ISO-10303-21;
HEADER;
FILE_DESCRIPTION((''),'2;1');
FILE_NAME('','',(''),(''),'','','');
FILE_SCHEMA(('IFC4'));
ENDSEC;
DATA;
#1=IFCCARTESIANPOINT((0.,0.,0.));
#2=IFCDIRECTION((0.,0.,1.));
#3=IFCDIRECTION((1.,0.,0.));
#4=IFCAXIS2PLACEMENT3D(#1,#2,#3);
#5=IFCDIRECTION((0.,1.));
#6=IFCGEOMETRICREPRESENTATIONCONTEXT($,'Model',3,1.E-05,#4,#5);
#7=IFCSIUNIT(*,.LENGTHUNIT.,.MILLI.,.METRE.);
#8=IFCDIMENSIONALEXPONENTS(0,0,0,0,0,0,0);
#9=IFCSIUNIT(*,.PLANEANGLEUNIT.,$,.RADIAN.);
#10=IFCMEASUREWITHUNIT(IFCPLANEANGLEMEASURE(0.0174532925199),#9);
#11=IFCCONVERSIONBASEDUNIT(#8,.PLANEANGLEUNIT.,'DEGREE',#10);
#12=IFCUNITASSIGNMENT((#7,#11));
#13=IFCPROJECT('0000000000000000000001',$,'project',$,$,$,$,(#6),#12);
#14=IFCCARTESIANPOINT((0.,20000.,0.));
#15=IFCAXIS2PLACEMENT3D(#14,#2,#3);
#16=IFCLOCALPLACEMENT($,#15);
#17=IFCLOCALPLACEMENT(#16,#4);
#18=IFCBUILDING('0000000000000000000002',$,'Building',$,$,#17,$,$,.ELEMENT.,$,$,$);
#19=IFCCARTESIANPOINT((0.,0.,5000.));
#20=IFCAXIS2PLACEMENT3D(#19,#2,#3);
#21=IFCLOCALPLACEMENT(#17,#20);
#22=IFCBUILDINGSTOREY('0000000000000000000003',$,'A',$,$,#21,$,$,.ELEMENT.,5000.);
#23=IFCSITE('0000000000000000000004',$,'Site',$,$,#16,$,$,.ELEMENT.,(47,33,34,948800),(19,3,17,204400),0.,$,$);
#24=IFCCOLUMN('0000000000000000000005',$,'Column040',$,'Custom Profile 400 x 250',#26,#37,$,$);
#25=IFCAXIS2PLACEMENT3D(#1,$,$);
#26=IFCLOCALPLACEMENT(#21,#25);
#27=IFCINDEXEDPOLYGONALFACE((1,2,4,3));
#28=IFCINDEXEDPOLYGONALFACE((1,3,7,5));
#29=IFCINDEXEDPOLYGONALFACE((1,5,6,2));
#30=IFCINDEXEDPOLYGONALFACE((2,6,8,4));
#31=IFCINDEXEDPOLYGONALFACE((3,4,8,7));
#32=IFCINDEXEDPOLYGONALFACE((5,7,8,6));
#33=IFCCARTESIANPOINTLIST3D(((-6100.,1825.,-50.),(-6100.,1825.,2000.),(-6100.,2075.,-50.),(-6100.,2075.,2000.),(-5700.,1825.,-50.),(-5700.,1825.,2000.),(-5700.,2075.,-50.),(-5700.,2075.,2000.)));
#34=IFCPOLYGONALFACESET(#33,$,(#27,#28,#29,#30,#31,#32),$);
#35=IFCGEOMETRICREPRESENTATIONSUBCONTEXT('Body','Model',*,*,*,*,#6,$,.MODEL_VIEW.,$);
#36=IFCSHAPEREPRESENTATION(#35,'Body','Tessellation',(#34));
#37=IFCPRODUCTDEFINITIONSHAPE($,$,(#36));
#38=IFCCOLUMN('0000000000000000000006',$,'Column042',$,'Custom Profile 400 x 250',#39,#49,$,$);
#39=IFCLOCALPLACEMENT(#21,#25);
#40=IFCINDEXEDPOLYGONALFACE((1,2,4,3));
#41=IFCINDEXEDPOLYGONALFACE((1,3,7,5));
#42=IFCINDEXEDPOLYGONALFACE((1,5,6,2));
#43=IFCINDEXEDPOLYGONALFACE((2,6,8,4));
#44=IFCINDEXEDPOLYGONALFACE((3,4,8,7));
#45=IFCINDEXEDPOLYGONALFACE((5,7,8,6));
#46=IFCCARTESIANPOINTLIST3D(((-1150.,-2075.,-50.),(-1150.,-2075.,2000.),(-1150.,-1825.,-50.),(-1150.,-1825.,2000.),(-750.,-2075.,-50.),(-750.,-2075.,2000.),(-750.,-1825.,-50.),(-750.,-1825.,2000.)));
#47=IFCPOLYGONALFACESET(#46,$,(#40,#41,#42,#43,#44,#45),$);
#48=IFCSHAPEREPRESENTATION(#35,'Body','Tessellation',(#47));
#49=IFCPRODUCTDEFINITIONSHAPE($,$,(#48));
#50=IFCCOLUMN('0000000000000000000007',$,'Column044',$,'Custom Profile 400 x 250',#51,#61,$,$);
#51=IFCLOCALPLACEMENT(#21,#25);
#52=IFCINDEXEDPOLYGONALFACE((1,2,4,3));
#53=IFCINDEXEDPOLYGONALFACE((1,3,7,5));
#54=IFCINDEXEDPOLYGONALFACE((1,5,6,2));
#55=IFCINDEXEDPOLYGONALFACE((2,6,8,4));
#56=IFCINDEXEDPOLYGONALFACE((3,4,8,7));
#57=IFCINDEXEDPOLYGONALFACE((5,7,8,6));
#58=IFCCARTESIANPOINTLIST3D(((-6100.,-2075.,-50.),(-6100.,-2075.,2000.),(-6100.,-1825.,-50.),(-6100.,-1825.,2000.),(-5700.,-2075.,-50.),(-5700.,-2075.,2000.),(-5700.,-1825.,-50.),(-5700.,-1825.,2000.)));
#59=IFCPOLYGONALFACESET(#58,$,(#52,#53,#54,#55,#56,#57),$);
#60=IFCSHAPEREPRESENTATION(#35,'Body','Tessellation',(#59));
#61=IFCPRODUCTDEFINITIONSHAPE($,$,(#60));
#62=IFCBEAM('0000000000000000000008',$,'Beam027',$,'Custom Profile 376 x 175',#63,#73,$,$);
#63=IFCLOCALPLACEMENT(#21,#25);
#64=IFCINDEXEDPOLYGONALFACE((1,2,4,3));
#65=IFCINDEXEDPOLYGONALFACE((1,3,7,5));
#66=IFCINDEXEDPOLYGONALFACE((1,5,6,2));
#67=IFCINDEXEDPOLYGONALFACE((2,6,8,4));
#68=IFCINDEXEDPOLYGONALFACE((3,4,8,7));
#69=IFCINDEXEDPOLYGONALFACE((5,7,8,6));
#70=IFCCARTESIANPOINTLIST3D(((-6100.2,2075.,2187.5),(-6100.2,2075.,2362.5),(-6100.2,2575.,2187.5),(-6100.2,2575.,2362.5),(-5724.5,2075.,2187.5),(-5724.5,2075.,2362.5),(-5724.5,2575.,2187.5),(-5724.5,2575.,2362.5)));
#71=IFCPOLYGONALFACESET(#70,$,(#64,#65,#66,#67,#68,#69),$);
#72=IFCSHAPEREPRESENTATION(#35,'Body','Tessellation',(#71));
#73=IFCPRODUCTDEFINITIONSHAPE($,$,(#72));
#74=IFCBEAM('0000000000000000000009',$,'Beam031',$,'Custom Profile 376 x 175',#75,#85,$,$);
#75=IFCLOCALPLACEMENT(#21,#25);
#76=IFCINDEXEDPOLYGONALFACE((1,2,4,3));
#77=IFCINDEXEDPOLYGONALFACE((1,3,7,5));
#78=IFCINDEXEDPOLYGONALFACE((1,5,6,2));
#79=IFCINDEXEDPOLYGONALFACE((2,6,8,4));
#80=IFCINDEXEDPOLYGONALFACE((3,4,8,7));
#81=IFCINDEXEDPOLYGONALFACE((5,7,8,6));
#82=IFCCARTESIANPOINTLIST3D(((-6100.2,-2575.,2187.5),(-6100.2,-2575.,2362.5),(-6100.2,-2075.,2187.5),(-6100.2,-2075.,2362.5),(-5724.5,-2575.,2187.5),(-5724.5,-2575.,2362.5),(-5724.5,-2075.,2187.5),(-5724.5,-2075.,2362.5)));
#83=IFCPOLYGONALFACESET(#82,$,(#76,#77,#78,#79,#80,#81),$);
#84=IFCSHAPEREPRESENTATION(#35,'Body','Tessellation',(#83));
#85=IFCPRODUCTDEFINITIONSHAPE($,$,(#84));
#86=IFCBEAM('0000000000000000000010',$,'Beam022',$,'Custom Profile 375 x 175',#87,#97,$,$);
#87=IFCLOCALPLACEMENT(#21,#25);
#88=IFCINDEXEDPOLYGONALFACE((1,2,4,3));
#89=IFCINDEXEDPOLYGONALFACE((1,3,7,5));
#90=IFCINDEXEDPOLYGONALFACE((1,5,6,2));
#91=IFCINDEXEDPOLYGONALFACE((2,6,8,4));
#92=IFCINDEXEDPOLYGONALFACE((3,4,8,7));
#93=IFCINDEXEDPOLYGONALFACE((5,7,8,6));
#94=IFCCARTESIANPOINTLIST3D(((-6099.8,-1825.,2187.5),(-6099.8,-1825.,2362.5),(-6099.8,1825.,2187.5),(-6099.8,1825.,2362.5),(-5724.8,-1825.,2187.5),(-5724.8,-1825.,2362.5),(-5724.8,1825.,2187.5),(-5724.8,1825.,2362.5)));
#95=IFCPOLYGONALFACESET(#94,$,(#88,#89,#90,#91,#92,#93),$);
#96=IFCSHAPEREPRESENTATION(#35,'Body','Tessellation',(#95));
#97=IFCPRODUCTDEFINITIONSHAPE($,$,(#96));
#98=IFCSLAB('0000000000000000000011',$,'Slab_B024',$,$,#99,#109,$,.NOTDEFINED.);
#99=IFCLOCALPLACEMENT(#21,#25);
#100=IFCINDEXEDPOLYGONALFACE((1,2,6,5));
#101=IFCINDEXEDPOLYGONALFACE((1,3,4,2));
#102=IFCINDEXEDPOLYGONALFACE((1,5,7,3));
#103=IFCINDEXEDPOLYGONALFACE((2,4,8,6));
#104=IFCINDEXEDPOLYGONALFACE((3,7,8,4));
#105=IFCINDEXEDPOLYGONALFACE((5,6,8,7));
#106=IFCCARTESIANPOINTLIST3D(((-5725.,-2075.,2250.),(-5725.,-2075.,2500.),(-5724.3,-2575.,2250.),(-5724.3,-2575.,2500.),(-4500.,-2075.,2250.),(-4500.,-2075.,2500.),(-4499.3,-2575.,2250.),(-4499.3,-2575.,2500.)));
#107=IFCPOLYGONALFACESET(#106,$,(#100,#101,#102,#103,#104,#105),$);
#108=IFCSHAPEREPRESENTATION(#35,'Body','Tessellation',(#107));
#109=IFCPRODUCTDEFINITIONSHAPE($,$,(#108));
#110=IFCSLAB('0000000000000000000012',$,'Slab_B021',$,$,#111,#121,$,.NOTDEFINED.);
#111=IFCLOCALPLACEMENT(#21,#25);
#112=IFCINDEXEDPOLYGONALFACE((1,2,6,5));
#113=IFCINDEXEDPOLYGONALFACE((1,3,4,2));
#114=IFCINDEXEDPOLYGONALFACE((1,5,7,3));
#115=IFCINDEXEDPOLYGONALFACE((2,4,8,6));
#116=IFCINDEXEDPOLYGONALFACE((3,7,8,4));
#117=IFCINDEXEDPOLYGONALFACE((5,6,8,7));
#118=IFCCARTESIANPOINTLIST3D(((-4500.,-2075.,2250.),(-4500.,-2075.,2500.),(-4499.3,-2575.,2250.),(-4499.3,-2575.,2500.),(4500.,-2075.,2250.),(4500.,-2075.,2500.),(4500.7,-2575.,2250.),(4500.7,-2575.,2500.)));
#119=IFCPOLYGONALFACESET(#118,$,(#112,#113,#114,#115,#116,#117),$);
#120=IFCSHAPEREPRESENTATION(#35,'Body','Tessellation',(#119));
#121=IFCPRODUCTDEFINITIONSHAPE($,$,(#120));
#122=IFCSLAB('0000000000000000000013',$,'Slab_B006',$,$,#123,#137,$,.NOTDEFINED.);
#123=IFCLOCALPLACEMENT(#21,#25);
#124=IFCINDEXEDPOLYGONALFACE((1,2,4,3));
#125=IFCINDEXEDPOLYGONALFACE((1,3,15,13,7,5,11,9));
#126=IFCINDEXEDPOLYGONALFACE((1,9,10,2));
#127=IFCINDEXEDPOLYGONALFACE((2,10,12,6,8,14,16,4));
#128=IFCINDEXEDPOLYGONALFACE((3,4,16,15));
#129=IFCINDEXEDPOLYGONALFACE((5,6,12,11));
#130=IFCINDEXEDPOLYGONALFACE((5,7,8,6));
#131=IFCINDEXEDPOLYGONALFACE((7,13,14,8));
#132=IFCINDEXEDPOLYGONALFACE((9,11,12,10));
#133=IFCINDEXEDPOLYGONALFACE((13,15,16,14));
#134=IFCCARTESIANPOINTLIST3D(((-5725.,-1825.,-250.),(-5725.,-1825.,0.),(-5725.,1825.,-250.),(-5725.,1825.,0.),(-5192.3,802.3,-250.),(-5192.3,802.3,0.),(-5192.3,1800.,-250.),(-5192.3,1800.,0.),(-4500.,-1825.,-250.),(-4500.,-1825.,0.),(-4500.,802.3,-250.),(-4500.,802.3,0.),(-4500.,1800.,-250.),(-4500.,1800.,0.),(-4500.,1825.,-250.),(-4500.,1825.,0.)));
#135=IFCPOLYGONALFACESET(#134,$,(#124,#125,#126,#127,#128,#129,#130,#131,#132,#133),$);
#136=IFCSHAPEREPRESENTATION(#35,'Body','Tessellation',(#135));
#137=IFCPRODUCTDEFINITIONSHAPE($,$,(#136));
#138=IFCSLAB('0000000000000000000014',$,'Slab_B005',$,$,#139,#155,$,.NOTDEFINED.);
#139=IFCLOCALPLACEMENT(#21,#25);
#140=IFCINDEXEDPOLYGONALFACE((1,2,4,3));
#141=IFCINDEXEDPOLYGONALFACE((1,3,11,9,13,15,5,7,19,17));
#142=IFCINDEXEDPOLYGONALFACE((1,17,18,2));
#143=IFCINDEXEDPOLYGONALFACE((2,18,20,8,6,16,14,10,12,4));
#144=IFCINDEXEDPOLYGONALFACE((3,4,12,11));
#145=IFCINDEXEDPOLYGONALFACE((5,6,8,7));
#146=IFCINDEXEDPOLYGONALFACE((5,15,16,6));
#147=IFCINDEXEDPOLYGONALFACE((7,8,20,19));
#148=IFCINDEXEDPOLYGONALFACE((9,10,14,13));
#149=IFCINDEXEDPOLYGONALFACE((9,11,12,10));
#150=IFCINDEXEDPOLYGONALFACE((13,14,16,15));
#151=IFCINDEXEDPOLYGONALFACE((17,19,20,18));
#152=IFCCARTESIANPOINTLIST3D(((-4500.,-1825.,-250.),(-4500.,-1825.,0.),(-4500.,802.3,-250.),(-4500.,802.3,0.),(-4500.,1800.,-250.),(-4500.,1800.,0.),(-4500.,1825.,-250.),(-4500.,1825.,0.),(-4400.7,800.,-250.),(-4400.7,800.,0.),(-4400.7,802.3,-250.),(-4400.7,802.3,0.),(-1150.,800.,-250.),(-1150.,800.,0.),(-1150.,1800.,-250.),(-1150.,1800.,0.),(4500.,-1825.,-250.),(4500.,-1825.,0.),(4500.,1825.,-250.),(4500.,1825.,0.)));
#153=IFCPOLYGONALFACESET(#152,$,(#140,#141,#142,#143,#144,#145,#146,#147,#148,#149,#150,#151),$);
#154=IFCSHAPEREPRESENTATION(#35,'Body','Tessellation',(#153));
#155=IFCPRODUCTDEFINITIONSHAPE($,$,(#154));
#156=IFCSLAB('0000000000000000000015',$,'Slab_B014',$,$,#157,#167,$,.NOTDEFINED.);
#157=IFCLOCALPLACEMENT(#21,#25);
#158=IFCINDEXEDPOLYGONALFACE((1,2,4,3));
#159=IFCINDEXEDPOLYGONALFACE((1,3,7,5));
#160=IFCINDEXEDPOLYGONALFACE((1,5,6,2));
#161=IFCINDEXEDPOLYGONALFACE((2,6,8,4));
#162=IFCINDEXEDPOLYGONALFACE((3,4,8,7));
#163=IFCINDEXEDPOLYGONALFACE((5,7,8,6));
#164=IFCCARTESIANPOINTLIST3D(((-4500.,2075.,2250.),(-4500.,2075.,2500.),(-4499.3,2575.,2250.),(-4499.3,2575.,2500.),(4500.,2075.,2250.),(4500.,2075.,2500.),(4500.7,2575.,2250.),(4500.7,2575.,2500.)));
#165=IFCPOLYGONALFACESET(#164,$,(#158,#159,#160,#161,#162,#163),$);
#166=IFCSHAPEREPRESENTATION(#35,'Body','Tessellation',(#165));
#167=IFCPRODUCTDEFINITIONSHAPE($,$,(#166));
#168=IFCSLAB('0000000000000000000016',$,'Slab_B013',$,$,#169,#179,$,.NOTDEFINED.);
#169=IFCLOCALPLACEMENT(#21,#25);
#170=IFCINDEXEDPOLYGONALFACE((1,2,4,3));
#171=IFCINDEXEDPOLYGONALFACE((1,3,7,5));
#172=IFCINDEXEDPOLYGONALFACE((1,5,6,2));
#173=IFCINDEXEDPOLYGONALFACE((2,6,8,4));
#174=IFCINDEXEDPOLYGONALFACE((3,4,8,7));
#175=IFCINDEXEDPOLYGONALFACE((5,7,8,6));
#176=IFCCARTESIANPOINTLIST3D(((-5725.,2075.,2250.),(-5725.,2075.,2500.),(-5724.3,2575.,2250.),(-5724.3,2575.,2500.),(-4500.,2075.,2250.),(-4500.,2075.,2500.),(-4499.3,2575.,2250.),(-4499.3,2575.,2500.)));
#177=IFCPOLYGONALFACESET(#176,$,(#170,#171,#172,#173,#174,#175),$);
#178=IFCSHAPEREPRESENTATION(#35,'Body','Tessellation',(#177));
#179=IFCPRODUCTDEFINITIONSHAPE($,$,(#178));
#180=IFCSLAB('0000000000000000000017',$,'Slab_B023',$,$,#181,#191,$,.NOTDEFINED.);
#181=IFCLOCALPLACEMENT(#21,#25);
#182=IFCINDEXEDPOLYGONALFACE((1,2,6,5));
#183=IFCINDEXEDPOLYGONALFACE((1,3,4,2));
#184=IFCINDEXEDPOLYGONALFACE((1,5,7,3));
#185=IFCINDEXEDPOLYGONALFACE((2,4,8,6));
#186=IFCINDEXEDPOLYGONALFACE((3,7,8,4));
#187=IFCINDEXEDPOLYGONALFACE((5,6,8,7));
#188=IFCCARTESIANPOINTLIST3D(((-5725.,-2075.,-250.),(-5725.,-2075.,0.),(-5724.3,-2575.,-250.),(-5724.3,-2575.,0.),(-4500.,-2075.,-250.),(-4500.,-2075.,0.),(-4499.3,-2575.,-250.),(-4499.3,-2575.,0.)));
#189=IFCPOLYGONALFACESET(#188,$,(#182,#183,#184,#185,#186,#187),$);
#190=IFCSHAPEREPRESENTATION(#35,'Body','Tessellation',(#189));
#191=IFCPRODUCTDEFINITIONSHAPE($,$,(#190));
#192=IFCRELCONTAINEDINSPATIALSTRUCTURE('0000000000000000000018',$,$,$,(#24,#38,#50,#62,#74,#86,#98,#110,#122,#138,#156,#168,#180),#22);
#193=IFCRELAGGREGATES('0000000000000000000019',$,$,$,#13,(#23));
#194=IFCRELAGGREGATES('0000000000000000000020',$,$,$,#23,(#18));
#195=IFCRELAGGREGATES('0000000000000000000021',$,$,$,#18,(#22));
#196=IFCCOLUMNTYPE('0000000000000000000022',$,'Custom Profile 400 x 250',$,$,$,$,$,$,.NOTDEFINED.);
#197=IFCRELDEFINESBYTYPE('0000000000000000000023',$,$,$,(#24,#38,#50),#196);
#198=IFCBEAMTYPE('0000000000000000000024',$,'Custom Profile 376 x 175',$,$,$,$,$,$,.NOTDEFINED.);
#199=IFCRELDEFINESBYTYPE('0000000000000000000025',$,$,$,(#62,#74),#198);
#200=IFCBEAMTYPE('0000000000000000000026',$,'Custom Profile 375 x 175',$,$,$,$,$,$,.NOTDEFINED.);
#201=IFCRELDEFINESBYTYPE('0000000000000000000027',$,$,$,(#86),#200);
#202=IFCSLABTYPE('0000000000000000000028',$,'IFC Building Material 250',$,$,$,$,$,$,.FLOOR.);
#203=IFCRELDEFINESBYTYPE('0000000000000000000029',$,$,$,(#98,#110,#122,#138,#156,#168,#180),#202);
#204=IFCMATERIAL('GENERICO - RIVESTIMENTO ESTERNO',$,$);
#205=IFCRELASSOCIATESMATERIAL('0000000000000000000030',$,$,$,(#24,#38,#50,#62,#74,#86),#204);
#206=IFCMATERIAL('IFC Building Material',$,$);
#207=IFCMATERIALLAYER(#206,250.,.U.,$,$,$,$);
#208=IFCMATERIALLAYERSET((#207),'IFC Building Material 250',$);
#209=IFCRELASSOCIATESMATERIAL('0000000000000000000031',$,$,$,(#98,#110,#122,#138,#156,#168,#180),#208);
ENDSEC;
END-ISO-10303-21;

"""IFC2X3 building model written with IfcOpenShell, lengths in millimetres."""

from ifc_helpers import new_model, entity, si_unit, converted_unit, direction, frame, frame_2d, origin_with_axes, origin_2d_with_axis, place, context, subcontext, project, spatial, polyline, rectangle, outline, extrude, material, layer, layer_set, layer_usage, type_object, element, save


model = new_model("IFC2X3")

# Units and contexts
model_context = context("Model", 3, precision=1e-05, world=origin_with_axes(), true_north=direction((0.0, 1.0)))
body_context = subcontext(model_context, "Body", "Model", "MODEL_VIEW")
ifc_project = project(units=[si_unit("LENGTHUNIT", "METRE", prefix="MILLI"), converted_unit("PLANEANGLEUNIT", "DEGREE", entity("IfcPlaneAngleMeasure", 0.0174532925199), si_unit("PLANEANGLEUNIT", "RADIAN"), dimensions=[0, 0, 0, 0, 0, 0, 0])], contexts=[model_context])

# Site, building, storey
site_placement = place(None, frame((0.0, 20000.0, 0.0), z_axis=(0.0, 0.0, 1.0), x_axis=(1.0, 0.0, 0.0)))
site = spatial("IfcSite", under=ifc_project, at=site_placement, Name="Site", CompositionType="ELEMENT", RefLatitude=(47, 33, 34, 948800), RefLongitude=(19, 3, 17, 204400), RefElevation=0.0)
building_placement = place(site_placement, origin_with_axes())
building = spatial("IfcBuilding", under=site, at=building_placement, Name="Building", CompositionType="ELEMENT")
storey_placement = place(building_placement, frame((0.0, 0.0, 5000.0), z_axis=(0.0, 0.0, 1.0), x_axis=(1.0, 0.0, 0.0)))
storey = spatial("IfcBuildingStorey", under=building, at=storey_placement, Name="A", CompositionType="ELEMENT", Elevation=5000.0)

# Columns
ifc_material_1 = material(Name="GENERICO - RIVESTIMENTO ESTERNO")
column_type = type_object("IfcColumnType", Name="Custom Profile 400 x 250", PredefinedType="NOTDEFINED")
for number, where, z_axis, x_axis, name in (
    (1, (-5900.0, 1950.0, -50.0), (0.0, 0.0, 1.0), (1.0, 0.0, 0.0), "Column040"),
    (2, (-950.0, -1950.0, -50.0), (0.0, 0.0, 1.0), (1.0, 0.0, 0.0), "Column042"),
    (3, (-5900.0, -1950.0, -50.0), (0.0, 0.0, 1.0), (1.0, 0.0, 0.0), "Column044"),
):
    element("IfcColumn", number, at=place(storey_placement, frame(where, z_axis=z_axis, x_axis=x_axis)), inside=storey, type_object=column_type, material=ifc_material_1, Name=name, ObjectType="Custom Profile 400 x 250", context=body_context, shape_type="SweptSolid", body=[
        extrude(rectangle(XDim=400.0, YDim=250.0, at=origin_2d_with_axis()), origin_with_axes(), (0.0, 0.0, 1.0), 2050.0),
    ])

# Beams
beam_type_1 = type_object("IfcBeamType", Name="Custom Profile 376 x 175", PredefinedType="NOTDEFINED")
for number, where, z_axis, x_axis, name in (
    (4, (-5912.3, 2075.0, 2362.5), (0.0, 0.0, 1.0), (1.0, 0.0, 0.0), "Beam027"),
    (5, (-5912.3, -2575.0, 2362.5), (0.0, 0.0, 1.0), (1.0, 0.0, 0.0), "Beam031"),
):
    element("IfcBeam", number, at=place(storey_placement, frame(where, z_axis=z_axis, x_axis=x_axis)), inside=storey, type_object=beam_type_1, material=ifc_material_1, Name=name, ObjectType="Custom Profile 376 x 175", context=body_context, shape_type="SweptSolid", body=[
        extrude(rectangle(XDim=175.0, YDim=375.7, at=frame_2d((-87.5, 0.0), x_axis=(1.0, 0.0))), frame((0.0, 0.0, 0.0), z_axis=(0.0, 1.0, 0.0), x_axis=(0.0, 0.0, 1.0)), (0.0, 0.0, 1.0), 500.0),
    ])
beam_type_2 = type_object("IfcBeamType", Name="Custom Profile 375 x 175", PredefinedType="NOTDEFINED")
beam_placement = place(storey_placement, frame((-5912.3, -1825.0, 2362.5), z_axis=(0.0, 0.0, 1.0), x_axis=(1.0, 0.0, 0.0)))
element("IfcBeam", 6, at=beam_placement, inside=storey, type_object=beam_type_2, material=ifc_material_1, Name="Beam022", ObjectType="Custom Profile 375 x 175", context=body_context, shape_type="SweptSolid", body=[
    extrude(rectangle(XDim=175.0, YDim=375.0, at=frame_2d((-87.5, 0.0), x_axis=(1.0, 0.0))), frame((0.0, 0.0, 0.0), z_axis=(0.0, 1.0, 0.0), x_axis=(0.0, 0.0, 1.0)), (0.0, 0.0, 1.0), 3650.0),
])

# Slabs
ifc_material_2 = material(Name="IFC Building Material")
ifc_layer_1 = layer(ifc_material_2, 250.0, ventilated="UNKNOWN")
ifc_layer_set_1 = layer_set([ifc_layer_1], Name="IFC Building Material 250")
ifc_layer_usage_1 = layer_usage(ifc_layer_set_1, "AXIS3", "NEGATIVE", 250.0)
slab_type_1 = type_object("IfcSlabType", Name="IFC Building Material 250", PredefinedType="FLOOR")
slab_1_placement = place(storey_placement, frame((-5725.0, -2075.0, 2500.0), z_axis=(0.0, 0.0, 1.0), x_axis=(1.0, 0.0, 0.0)))
element("IfcSlab", 7, at=slab_1_placement, inside=storey, type_object=slab_type_1, material=ifc_layer_usage_1, Name="Slab_B024", PredefinedType="NOTDEFINED", context=body_context, shape_type="SweptSolid", body=[
    extrude(outline(polyline([(0.0, 0.0), (0.7, -500.0), (1225.7, -500.0), (1225.0, 0.0), (0.0, 0.0)])), frame((0.0, 0.0, -250.0), z_axis=(0.0, 0.0, 1.0), x_axis=(1.0, 0.0, 0.0)), (0.0, 0.0, 1.0), 250.0),
])
ifc_layer_usage_2 = layer_usage(ifc_layer_set_1, "AXIS3", "NEGATIVE", 250.0)
slab_2_placement = place(storey_placement, frame((-4500.0, -2075.0, 2500.0), z_axis=(0.0, 0.0, 1.0), x_axis=(1.0, 0.0, 0.0)))
element("IfcSlab", 8, at=slab_2_placement, inside=storey, type_object=slab_type_1, material=ifc_layer_usage_2, Name="Slab_B021", PredefinedType="NOTDEFINED", context=body_context, shape_type="SweptSolid", body=[
    extrude(outline(polyline([(0.0, 0.0), (0.7, -500.0), (9000.7, -500.0), (9000.0, 0.0), (0.0, 0.0)])), frame((0.0, 0.0, -250.0), z_axis=(0.0, 0.0, 1.0), x_axis=(1.0, 0.0, 0.0)), (0.0, 0.0, 1.0), 250.0),
])
ifc_layer_usage_3 = layer_usage(ifc_layer_set_1, "AXIS3", "NEGATIVE", 250.0)
slab_3_placement = place(storey_placement, frame((-5725.0, -1825.0, 0.0), z_axis=(0.0, 0.0, 1.0), x_axis=(1.0, 0.0, 0.0)))
element("IfcSlab", 9, at=slab_3_placement, inside=storey, type_object=slab_type_1, material=ifc_layer_usage_3, Name="Slab_B006", PredefinedType="NOTDEFINED", context=body_context, shape_type="SweptSolid", body=[
    extrude(outline(polyline([(0.0, 0.0), (1225.0, 0.0), (1225.0, 2627.3), (532.7, 2627.3), (532.7, 3625.0), (1225.0, 3625.0), (1225.0, 3650.0), (0.0, 3650.0), (0.0, 0.0)])), frame((0.0, 0.0, -250.0), z_axis=(0.0, 0.0, 1.0), x_axis=(1.0, 0.0, 0.0)), (0.0, 0.0, 1.0), 250.0),
])
ifc_layer_usage_4 = layer_usage(ifc_layer_set_1, "AXIS3", "NEGATIVE", 250.0)
slab_4_placement = place(storey_placement, frame((-4500.0, -1825.0, 0.0), z_axis=(0.0, 0.0, 1.0), x_axis=(1.0, 0.0, 0.0)))
element("IfcSlab", 10, at=slab_4_placement, inside=storey, type_object=slab_type_1, material=ifc_layer_usage_4, Name="Slab_B005", PredefinedType="NOTDEFINED", context=body_context, shape_type="SweptSolid", body=[
    extrude(outline(polyline([(0.0, 0.0), (9000.0, 0.0), (9000.0, 3650.0), (0.0, 3650.0), (0.0, 3625.0), (3350.0, 3625.0), (3350.0, 2625.0), (99.3, 2625.0), (99.3, 2627.3), (0.0, 2627.3), (0.0, 0.0)])), frame((0.0, 0.0, -250.0), z_axis=(0.0, 0.0, 1.0), x_axis=(1.0, 0.0, 0.0)), (0.0, 0.0, 1.0), 250.0),
])
ifc_layer_usage_5 = layer_usage(ifc_layer_set_1, "AXIS3", "NEGATIVE", 250.0)
slab_5_placement = place(storey_placement, frame((-4499.3, 2575.0, 2500.0), z_axis=(0.0, 0.0, 1.0), x_axis=(1.0, 0.0, 0.0)))
element("IfcSlab", 11, at=slab_5_placement, inside=storey, type_object=slab_type_1, material=ifc_layer_usage_5, Name="Slab_B014", PredefinedType="NOTDEFINED", context=body_context, shape_type="SweptSolid", body=[
    extrude(outline(polyline([(0.0, 0.0), (-0.7, -500.0), (8999.3, -500.0), (9000.0, 0.0), (0.0, 0.0)])), frame((0.0, 0.0, -250.0), z_axis=(0.0, 0.0, 1.0), x_axis=(1.0, 0.0, 0.0)), (0.0, 0.0, 1.0), 250.0),
])
ifc_layer_usage_6 = layer_usage(ifc_layer_set_1, "AXIS3", "NEGATIVE", 250.0)
slab_6_placement = place(storey_placement, frame((-5724.3, 2575.0, 2500.0), z_axis=(0.0, 0.0, 1.0), x_axis=(1.0, 0.0, 0.0)))
element("IfcSlab", 12, at=slab_6_placement, inside=storey, type_object=slab_type_1, material=ifc_layer_usage_6, Name="Slab_B013", PredefinedType="NOTDEFINED", context=body_context, shape_type="SweptSolid", body=[
    extrude(outline(polyline([(0.0, 0.0), (-0.7, -500.0), (1224.3, -500.0), (1225.0, 0.0), (0.0, 0.0)])), frame((0.0, 0.0, -250.0), z_axis=(0.0, 0.0, 1.0), x_axis=(1.0, 0.0, 0.0)), (0.0, 0.0, 1.0), 250.0),
])
ifc_layer_usage_7 = layer_usage(ifc_layer_set_1, "AXIS3", "NEGATIVE", 250.0)
slab_7_placement = place(storey_placement, frame((-5725.0, -2075.0, 0.0), z_axis=(0.0, 0.0, 1.0), x_axis=(1.0, 0.0, 0.0)))
element("IfcSlab", 13, at=slab_7_placement, inside=storey, type_object=slab_type_1, material=ifc_layer_usage_7, Name="Slab_B023", PredefinedType="NOTDEFINED", context=body_context, shape_type="SweptSolid", body=[
    extrude(outline(polyline([(0.0, 0.0), (0.7, -500.0), (1225.7, -500.0), (1225.0, 0.0), (0.0, 0.0)])), frame((0.0, 0.0, -250.0), z_axis=(0.0, 0.0, 1.0), x_axis=(1.0, 0.0, 0.0)), (0.0, 0.0, 1.0), 250.0),
])

save(model, "model.ifc")
